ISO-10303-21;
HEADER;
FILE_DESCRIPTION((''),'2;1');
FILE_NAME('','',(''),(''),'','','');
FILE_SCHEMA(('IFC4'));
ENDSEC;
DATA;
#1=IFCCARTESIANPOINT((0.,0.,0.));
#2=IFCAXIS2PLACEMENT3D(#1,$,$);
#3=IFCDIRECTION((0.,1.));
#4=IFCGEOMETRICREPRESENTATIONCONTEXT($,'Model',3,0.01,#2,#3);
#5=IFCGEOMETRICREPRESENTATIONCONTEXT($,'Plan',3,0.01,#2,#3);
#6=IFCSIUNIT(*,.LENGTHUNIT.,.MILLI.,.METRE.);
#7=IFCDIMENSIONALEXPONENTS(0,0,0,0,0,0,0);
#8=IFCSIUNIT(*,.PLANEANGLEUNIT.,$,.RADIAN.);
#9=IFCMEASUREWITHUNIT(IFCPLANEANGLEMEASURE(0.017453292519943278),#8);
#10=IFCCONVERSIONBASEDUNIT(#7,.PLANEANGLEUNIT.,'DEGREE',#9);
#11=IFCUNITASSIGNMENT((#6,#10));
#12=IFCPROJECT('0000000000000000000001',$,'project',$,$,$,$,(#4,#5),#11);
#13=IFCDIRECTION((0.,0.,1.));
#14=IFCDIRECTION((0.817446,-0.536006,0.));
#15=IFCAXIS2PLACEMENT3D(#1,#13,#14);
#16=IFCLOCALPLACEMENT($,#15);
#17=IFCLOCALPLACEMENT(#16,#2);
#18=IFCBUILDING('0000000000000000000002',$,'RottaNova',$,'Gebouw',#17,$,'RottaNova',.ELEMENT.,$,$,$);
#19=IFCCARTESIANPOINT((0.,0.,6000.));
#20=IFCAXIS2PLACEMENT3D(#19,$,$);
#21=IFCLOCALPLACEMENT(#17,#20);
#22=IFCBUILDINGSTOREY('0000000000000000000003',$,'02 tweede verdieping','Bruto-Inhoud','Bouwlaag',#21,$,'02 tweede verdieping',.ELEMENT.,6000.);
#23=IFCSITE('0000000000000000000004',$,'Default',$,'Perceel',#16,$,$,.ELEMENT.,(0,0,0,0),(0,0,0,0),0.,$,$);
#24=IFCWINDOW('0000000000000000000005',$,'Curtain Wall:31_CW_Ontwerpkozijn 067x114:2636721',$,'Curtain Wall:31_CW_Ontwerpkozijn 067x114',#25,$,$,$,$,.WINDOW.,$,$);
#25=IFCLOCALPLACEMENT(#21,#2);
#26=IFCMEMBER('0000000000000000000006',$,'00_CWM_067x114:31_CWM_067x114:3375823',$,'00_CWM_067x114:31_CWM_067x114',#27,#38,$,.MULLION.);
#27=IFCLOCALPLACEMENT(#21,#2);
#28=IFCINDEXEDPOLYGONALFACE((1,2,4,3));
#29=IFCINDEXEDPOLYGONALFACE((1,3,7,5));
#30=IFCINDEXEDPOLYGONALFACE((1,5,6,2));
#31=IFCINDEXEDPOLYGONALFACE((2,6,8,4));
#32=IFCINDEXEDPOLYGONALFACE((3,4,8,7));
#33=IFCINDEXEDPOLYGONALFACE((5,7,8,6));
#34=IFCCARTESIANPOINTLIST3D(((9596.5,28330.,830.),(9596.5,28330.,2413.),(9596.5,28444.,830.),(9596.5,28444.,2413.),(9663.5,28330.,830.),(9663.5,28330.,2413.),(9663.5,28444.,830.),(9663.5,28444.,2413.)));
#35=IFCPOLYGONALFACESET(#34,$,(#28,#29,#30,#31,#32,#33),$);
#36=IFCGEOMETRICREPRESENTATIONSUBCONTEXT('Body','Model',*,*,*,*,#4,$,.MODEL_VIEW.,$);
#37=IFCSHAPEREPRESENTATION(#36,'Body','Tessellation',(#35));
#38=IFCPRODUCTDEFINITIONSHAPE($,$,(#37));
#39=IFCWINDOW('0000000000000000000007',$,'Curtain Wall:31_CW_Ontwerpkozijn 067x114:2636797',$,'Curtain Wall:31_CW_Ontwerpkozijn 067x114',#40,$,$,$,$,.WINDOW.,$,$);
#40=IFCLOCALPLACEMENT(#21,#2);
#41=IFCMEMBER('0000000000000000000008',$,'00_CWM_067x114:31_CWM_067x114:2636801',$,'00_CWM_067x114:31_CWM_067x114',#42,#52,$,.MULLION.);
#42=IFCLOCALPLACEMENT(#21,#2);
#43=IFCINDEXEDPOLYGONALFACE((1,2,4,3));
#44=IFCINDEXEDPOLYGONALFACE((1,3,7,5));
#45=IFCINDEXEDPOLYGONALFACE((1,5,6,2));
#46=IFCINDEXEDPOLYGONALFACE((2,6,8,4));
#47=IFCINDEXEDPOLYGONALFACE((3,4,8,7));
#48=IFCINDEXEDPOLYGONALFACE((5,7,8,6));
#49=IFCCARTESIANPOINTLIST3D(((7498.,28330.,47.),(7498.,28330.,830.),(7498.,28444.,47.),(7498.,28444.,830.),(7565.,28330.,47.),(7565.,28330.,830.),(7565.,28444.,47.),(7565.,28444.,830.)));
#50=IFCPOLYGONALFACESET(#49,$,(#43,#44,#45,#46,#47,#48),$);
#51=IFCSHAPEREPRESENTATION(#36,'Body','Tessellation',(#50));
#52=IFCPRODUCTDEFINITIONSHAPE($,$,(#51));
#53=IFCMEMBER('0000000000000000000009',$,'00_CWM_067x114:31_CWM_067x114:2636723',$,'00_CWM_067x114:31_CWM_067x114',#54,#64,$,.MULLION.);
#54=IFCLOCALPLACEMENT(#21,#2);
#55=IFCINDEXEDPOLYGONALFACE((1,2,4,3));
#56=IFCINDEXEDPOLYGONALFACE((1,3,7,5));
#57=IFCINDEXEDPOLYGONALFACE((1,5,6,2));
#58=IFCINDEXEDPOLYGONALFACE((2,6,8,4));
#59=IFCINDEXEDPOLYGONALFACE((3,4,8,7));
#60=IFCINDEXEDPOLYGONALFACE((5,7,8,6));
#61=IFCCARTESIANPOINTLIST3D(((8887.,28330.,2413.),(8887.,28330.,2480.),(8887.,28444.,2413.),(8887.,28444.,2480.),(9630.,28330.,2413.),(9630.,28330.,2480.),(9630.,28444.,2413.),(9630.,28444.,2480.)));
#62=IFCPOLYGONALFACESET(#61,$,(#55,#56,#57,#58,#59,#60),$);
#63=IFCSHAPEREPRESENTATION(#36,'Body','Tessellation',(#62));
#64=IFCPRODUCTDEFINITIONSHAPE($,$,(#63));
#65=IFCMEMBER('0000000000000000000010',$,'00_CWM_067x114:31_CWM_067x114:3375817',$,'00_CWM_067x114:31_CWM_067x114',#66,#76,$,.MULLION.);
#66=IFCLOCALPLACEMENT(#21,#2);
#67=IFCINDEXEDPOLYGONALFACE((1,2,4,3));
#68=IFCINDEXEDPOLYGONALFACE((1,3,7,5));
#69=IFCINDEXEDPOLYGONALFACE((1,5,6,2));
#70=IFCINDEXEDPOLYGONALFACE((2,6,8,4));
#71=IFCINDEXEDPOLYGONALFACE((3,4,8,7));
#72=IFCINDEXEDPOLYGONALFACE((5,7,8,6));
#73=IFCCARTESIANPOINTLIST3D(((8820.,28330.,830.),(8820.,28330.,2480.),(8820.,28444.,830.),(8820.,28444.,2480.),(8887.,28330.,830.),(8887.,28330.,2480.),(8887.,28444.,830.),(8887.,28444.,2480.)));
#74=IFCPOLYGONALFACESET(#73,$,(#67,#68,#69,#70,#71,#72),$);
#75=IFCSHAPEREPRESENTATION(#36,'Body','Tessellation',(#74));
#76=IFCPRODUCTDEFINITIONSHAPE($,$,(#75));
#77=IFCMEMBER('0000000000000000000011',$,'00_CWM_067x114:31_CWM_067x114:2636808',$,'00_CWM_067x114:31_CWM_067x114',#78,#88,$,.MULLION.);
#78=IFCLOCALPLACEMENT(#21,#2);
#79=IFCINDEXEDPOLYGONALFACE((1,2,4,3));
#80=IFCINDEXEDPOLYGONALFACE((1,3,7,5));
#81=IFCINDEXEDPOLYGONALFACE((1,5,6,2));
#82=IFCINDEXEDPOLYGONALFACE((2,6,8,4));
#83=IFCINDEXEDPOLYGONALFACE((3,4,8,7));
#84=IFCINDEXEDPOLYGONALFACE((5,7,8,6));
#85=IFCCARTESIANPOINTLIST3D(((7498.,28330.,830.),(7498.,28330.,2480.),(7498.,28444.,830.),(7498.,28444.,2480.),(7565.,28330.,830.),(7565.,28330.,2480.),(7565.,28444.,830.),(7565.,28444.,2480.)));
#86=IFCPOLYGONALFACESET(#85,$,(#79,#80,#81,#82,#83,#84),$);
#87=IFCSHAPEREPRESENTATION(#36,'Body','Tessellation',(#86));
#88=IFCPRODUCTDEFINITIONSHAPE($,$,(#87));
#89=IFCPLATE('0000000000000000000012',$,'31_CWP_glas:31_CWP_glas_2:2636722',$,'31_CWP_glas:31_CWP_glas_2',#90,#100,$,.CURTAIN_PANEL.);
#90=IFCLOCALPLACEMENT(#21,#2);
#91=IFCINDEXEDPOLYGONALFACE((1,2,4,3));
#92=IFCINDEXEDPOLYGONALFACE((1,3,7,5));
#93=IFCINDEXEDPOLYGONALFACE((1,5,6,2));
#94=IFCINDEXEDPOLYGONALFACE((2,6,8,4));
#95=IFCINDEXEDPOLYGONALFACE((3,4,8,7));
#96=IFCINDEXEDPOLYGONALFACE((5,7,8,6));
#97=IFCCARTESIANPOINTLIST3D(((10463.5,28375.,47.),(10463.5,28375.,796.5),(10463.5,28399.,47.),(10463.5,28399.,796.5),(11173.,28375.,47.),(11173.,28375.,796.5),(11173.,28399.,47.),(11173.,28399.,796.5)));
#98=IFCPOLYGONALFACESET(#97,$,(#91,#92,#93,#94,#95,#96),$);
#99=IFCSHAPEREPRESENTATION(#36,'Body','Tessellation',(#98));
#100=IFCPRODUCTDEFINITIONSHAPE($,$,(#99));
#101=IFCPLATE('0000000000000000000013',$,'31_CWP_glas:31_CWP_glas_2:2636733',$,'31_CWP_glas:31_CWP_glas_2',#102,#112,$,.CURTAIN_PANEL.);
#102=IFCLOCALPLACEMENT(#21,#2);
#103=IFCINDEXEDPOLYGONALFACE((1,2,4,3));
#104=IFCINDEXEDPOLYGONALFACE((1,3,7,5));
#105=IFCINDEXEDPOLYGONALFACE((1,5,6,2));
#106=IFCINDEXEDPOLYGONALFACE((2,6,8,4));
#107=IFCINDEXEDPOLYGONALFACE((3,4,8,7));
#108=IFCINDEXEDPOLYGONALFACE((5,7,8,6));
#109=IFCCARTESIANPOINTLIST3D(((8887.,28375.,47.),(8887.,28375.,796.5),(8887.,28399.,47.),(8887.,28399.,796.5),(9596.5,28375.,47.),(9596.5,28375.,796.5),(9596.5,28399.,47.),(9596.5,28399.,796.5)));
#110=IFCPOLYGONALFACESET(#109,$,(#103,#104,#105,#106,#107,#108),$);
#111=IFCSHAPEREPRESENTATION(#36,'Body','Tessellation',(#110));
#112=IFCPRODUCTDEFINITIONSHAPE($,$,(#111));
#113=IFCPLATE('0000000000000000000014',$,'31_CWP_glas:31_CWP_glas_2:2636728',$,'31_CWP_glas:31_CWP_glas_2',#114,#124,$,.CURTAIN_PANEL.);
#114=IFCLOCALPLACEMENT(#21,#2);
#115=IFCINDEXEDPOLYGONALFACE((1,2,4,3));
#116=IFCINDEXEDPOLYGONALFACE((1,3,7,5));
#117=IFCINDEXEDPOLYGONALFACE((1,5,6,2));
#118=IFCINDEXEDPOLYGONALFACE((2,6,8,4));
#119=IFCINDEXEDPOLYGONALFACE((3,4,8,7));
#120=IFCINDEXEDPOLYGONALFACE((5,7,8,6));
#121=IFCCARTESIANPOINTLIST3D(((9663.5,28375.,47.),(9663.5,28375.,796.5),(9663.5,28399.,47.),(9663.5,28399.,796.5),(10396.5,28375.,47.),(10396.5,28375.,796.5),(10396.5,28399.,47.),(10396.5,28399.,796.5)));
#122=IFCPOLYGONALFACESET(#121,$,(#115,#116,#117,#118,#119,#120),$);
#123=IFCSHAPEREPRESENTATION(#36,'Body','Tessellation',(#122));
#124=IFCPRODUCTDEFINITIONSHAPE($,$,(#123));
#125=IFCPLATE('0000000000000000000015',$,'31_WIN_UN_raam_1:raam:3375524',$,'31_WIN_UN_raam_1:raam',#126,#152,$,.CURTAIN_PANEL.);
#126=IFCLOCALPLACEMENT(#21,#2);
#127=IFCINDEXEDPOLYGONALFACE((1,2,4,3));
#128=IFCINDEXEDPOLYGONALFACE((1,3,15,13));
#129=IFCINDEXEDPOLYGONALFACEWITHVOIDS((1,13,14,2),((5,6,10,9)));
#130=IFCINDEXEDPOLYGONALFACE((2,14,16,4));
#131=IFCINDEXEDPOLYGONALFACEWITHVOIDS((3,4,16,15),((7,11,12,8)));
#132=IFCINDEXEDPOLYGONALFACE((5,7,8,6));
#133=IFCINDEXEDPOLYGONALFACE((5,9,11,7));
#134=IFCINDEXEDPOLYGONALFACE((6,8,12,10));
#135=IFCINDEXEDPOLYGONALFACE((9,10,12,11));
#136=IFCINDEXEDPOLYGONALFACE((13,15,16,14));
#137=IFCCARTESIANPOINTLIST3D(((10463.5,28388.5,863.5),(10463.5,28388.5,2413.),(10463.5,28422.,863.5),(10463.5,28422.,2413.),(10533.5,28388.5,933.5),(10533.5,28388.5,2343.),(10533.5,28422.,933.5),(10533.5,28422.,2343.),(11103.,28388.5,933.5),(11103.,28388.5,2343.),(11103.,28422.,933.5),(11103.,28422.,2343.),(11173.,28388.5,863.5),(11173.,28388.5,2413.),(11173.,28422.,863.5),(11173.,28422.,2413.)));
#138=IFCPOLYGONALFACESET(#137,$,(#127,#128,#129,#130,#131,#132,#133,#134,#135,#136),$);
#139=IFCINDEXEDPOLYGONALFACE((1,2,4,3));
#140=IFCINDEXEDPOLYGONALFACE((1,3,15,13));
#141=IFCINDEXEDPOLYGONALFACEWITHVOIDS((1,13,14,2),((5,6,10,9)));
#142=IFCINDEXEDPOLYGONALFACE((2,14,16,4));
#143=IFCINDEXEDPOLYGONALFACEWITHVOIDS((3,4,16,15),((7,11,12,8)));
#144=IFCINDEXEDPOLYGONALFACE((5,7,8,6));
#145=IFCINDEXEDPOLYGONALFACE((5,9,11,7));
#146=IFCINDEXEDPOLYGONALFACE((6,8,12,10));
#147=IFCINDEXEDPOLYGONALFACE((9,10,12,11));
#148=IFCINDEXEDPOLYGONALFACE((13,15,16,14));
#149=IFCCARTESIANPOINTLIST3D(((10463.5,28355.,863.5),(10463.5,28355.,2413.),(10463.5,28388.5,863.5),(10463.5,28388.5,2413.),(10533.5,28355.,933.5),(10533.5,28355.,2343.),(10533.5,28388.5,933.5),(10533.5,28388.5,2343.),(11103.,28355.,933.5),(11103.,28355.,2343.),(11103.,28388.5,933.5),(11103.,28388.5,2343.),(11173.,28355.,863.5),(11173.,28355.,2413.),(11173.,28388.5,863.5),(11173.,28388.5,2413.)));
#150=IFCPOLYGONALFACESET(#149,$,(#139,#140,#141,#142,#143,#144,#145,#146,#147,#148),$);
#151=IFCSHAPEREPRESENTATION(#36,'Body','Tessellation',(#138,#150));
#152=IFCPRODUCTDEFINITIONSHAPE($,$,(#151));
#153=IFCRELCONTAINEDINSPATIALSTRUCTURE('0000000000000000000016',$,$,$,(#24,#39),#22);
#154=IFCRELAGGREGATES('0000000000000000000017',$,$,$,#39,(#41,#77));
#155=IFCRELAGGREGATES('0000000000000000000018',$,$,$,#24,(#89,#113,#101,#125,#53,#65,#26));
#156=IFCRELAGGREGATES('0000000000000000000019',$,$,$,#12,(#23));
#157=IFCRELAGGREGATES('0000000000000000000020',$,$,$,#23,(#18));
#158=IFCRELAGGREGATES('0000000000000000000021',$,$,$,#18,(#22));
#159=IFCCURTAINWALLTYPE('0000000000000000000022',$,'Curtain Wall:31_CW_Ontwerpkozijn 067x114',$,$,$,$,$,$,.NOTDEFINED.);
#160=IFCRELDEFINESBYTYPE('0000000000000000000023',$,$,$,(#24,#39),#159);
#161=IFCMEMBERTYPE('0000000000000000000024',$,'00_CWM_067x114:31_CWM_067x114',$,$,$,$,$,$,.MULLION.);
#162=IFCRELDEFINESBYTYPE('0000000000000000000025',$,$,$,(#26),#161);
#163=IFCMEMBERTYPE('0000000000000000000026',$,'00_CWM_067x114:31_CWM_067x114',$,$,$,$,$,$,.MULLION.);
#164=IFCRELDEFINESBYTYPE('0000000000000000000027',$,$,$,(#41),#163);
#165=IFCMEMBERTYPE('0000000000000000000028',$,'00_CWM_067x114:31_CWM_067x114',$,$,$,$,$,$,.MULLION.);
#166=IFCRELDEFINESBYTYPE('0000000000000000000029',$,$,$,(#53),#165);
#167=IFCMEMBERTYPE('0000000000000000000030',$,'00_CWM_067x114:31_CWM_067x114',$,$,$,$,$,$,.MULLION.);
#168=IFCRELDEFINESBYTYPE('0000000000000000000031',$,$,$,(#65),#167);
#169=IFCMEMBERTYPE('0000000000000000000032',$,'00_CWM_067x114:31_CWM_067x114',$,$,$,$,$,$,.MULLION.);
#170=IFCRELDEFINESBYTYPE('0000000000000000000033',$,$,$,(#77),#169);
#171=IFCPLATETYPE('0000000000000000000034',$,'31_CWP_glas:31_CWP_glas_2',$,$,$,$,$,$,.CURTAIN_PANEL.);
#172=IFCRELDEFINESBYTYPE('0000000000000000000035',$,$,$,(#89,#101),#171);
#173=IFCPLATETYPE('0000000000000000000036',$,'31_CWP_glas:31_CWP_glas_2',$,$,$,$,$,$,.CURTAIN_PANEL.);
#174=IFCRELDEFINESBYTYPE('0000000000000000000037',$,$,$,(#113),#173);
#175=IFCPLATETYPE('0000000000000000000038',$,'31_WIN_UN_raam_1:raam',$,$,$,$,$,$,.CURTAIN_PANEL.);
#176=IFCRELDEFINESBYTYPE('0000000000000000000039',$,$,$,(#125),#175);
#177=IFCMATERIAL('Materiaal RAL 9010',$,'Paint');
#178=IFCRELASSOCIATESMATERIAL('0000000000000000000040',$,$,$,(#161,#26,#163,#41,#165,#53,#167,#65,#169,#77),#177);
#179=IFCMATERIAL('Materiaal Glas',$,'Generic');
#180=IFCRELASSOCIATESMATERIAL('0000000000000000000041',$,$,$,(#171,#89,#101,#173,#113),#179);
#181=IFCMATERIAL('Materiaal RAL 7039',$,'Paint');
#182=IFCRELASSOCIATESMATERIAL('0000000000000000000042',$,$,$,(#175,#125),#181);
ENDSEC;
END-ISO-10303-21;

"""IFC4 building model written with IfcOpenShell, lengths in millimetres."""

from ifc_helpers import new_model, entity, si_unit, converted_unit, direction, frame, origin, place, context, subcontext, project, spatial, indexed_curve, outline, extrude, source, transform, mapped, material, type_object, type_shapes, element, aggregate, save


model = new_model("IFC4")

# Units and contexts
model_context = context("Model", 3, precision=0.01, world=origin(), true_north=direction((0.0, 1.0)))
plan_context = context("Plan", 3, precision=0.01, world=origin(), true_north=direction((0.0, 1.0)))
body_context = subcontext(model_context, "Body", "Model", "MODEL_VIEW")
ifc_project = project(units=[si_unit("LENGTHUNIT", "METRE", prefix="MILLI"), converted_unit("PLANEANGLEUNIT", "DEGREE", entity("IfcPlaneAngleMeasure", 0.017453292519943278), si_unit("PLANEANGLEUNIT", "RADIAN"), dimensions=[0, 0, 0, 0, 0, 0, 0])], contexts=[model_context, plan_context])

# Site, building, storey
site_placement = place(None, frame((0.0, 0.0, 0.0), z_axis=(0.0, 0.0, 1.0), x_axis=(0.817446, -0.536006, 0.0)))
site = spatial("IfcSite", under=ifc_project, at=site_placement, Name="Default", ObjectType="Perceel", CompositionType="ELEMENT", RefLatitude=(0, 0, 0, 0), RefLongitude=(0, 0, 0, 0), RefElevation=0.0)
building_placement = place(site_placement, origin())
building = spatial("IfcBuilding", under=site, at=building_placement, Name="RottaNova", ObjectType="Gebouw", LongName="RottaNova", CompositionType="ELEMENT")
storey_placement = place(building_placement, frame((0.0, 0.0, 6000.0)))
storey = spatial("IfcBuildingStorey", under=building, at=storey_placement, Name="02 tweede verdieping", Description="Bruto-Inhoud", ObjectType="Bouwlaag", LongName="02 tweede verdieping", CompositionType="ELEMENT", Elevation=6000.0)

# Window, member
curtain_wall_type = type_object("IfcCurtainWallType", Name="Curtain Wall:31_CW_Ontwerpkozijn 067x114", PredefinedType="NOTDEFINED")
window_1_placement = place(storey_placement, frame((0.0, 0.0, -6000.0)))
window_1 = element("IfcWindow", 1, at=window_1_placement, inside=storey, type_object=curtain_wall_type, Name="Curtain Wall:31_CW_Ontwerpkozijn 067x114:2636721", ObjectType="Curtain Wall:31_CW_Ontwerpkozijn 067x114", PredefinedType="WINDOW")
ifc_material_1 = material(Name="Materiaal RAL 9010", Category="Paint")
member_type_1 = type_object("IfcMemberType", Name="00_CWM_067x114:31_CWM_067x114", PredefinedType="MULLION", material=ifc_material_1)
shared_shape_1 = source(origin(), body_context, "Body", "SweptSolid", [
    extrude(outline(indexed_curve([(-33.5, -57.0), (33.5, -57.0), (33.5, 57.0), (-33.5, 57.0), (-33.5, -57.0)], self_intersect=False)), frame((0.0, 57.0, -1583.0), z_axis=(0.0, 0.0, 1.0), x_axis=(-1.0, 0.0, 0.0)), (0.0, 0.0, 1.0), 1583.0),
])
type_shapes(member_type_1, [shared_shape_1])
member_1_placement = place(window_1_placement, frame((9630.0, 28330.0, 6830.0), z_axis=(0.0, 0.0, -1.0), x_axis=(-1.0, 0.0, 0.0)))
member_1 = element("IfcMember", 2, at=member_1_placement, type_object=member_type_1, material=ifc_material_1, Name="00_CWM_067x114:31_CWM_067x114:3375823", ObjectType="00_CWM_067x114:31_CWM_067x114", PredefinedType="MULLION", context=body_context, shape_type="MappedRepresentation", body=[
    mapped(shared_shape_1, transform((0.0, 0.0, 0.0), scale=1.0)),
])

# Window, member
window_2_placement = place(storey_placement, frame((0.0, 0.0, -6000.0)))
window_2 = element("IfcWindow", 3, at=window_2_placement, inside=storey, type_object=curtain_wall_type, Name="Curtain Wall:31_CW_Ontwerpkozijn 067x114:2636797", ObjectType="Curtain Wall:31_CW_Ontwerpkozijn 067x114", PredefinedType="WINDOW")
member_type_2 = type_object("IfcMemberType", Name="00_CWM_067x114:31_CWM_067x114", PredefinedType="MULLION", material=ifc_material_1)
shared_shape_2 = source(origin(), body_context, "Body", "SweptSolid", [
    extrude(outline(indexed_curve([(-33.5, -57.0), (33.5, -57.0), (33.5, 57.0), (-33.5, 57.0), (-33.5, -57.0)], self_intersect=False)), frame((-33.5, -57.0, -783.0), z_axis=(0.0, 0.0, 1.0), x_axis=(-1.0, 0.0, 0.0)), (0.0, 0.0, 1.0), 783.0),
])
type_shapes(member_type_2, [shared_shape_2])
member_2_placement = place(window_2_placement, frame((7565.0, 28330.0, 6047.0), z_axis=(0.0, 0.0, -1.0), x_axis=(1.0, 0.0, 0.0)))
member_2 = element("IfcMember", 4, at=member_2_placement, type_object=member_type_2, material=ifc_material_1, Name="00_CWM_067x114:31_CWM_067x114:2636801", ObjectType="00_CWM_067x114:31_CWM_067x114", PredefinedType="MULLION", context=body_context, shape_type="MappedRepresentation", body=[
    mapped(shared_shape_2, transform((0.0, 0.0, 0.0), scale=1.0)),
])

# Members
member_type_3 = type_object("IfcMemberType", Name="00_CWM_067x114:31_CWM_067x114", PredefinedType="MULLION", material=ifc_material_1)
shared_shape_3 = source(origin(), body_context, "Body", "SweptSolid", [
    extrude(outline(indexed_curve([(-33.5, -57.0), (33.5, -57.0), (33.5, 57.0), (-33.5, 57.0), (-33.5, -57.0)], self_intersect=False)), frame((-33.5, 57.0, -743.0), z_axis=(0.0, 0.0, 1.0), x_axis=(-1.0, 0.0, 0.0)), (0.0, 0.0, 1.0), 743.0),
])
type_shapes(member_type_3, [shared_shape_3])
member_3_placement = place(window_1_placement, frame((8887.0, 28330.0, 8480.0), z_axis=(-1.0, 0.0, 0.0), x_axis=(0.0, 0.0, 1.0)))
member_3 = element("IfcMember", 5, at=member_3_placement, type_object=member_type_3, material=ifc_material_1, Name="00_CWM_067x114:31_CWM_067x114:2636723", ObjectType="00_CWM_067x114:31_CWM_067x114", PredefinedType="MULLION", context=body_context, shape_type="MappedRepresentation", body=[
    mapped(shared_shape_3, transform((0.0, 0.0, 0.0), scale=1.0)),
])
member_type_4 = type_object("IfcMemberType", Name="00_CWM_067x114:31_CWM_067x114", PredefinedType="MULLION", material=ifc_material_1)
shared_shape_4 = source(origin(), body_context, "Body", "SweptSolid", [
    extrude(outline(indexed_curve([(-33.5, -57.0), (33.5, -57.0), (33.5, 57.0), (-33.5, 57.0), (-33.5, -57.0)], self_intersect=False)), frame((-33.5, 57.0, -1650.0), z_axis=(0.0, 0.0, 1.0), x_axis=(-1.0, 0.0, 0.0)), (0.0, 0.0, 1.0), 1650.0),
])
type_shapes(member_type_4, [shared_shape_4])
member_4_placement = place(window_1_placement, frame((8820.0, 28330.0, 6830.0), z_axis=(0.0, 0.0, -1.0), x_axis=(-1.0, 0.0, 0.0)))
member_4 = element("IfcMember", 6, at=member_4_placement, type_object=member_type_4, material=ifc_material_1, Name="00_CWM_067x114:31_CWM_067x114:3375817", ObjectType="00_CWM_067x114:31_CWM_067x114", PredefinedType="MULLION", context=body_context, shape_type="MappedRepresentation", body=[
    mapped(shared_shape_4, transform((0.0, 0.0, 0.0), scale=1.0)),
])
member_type_5 = type_object("IfcMemberType", Name="00_CWM_067x114:31_CWM_067x114", PredefinedType="MULLION", material=ifc_material_1)
shared_shape_5 = source(origin(), body_context, "Body", "SweptSolid", [
    extrude(outline(indexed_curve([(-33.5, -57.0), (33.5, -57.0), (33.5, 57.0), (-33.5, 57.0), (-33.5, -57.0)], self_intersect=False)), frame((-33.5, -57.0, -1650.0), z_axis=(0.0, 0.0, 1.0), x_axis=(-1.0, 0.0, 0.0)), (0.0, 0.0, 1.0), 1650.0),
])
type_shapes(member_type_5, [shared_shape_5])
member_5_placement = place(window_2_placement, frame((7565.0, 28330.0, 6830.0), z_axis=(0.0, 0.0, -1.0), x_axis=(1.0, 0.0, 0.0)))
member_5 = element("IfcMember", 7, at=member_5_placement, type_object=member_type_5, material=ifc_material_1, Name="00_CWM_067x114:31_CWM_067x114:2636808", ObjectType="00_CWM_067x114:31_CWM_067x114", PredefinedType="MULLION", context=body_context, shape_type="MappedRepresentation", body=[
    mapped(shared_shape_5, transform((0.0, 0.0, 0.0), scale=1.0)),
])
aggregate(window_2, [member_2, member_5])

# Plates
ifc_material_2 = material(Name="Materiaal Glas", Category="Generic")
plate_type_1 = type_object("IfcPlateType", Name="31_CWP_glas:31_CWP_glas_2", PredefinedType="CURTAIN_PANEL", material=ifc_material_2)
shared_shape_6 = source(origin(), body_context, "Body", "SweptSolid", [
    extrude(outline(indexed_curve([(-12.0, -354.8), (12.0, -354.8), (12.0, 354.8), (-12.0, 354.8), (-12.0, -354.8)], self_intersect=False)), frame((0.0, -57.0, 0.0), z_axis=(0.0, 0.0, 1.0), x_axis=(0.0, 1.0, 0.0)), (0.0, 0.0, 1.0), 749.5),
])
type_shapes(plate_type_1, [shared_shape_6])
plate_1_placement = place(window_1_placement, frame((10818.2, 28330.0, 6047.0), z_axis=(0.0, 0.0, 1.0), x_axis=(-1.0, 0.0, 0.0)))
plate_1 = element("IfcPlate", 8, at=plate_1_placement, type_object=plate_type_1, material=ifc_material_2, Name="31_CWP_glas:31_CWP_glas_2:2636722", ObjectType="31_CWP_glas:31_CWP_glas_2", PredefinedType="CURTAIN_PANEL", context=body_context, shape_type="MappedRepresentation", body=[
    mapped(shared_shape_6, transform((0.0, 0.0, 0.0), scale=1.0)),
])
plate_2_placement = place(window_1_placement, frame((9241.7, 28330.0, 6047.0), z_axis=(0.0, 0.0, 1.0), x_axis=(-1.0, 0.0, 0.0)))
plate_2 = element("IfcPlate", 9, at=plate_2_placement, type_object=plate_type_1, material=ifc_material_2, Name="31_CWP_glas:31_CWP_glas_2:2636733", ObjectType="31_CWP_glas:31_CWP_glas_2", PredefinedType="CURTAIN_PANEL", context=body_context, shape_type="MappedRepresentation", body=[
    mapped(shared_shape_6, transform((0.0, 0.0, 0.0), scale=1.0)),
])
plate_type_2 = type_object("IfcPlateType", Name="31_CWP_glas:31_CWP_glas_2", PredefinedType="CURTAIN_PANEL", material=ifc_material_2)
shared_shape_7 = source(origin(), body_context, "Body", "SweptSolid", [
    extrude(outline(indexed_curve([(-12.0, -366.5), (12.0, -366.5), (12.0, 366.5), (-12.0, 366.5), (-12.0, -366.5)], self_intersect=False)), frame((0.0, -57.0, 0.0), z_axis=(0.0, 0.0, 1.0), x_axis=(0.0, 1.0, 0.0)), (0.0, 0.0, 1.0), 749.5),
])
type_shapes(plate_type_2, [shared_shape_7])
plate_3_placement = place(window_1_placement, frame((10030.0, 28330.0, 6047.0), z_axis=(0.0, 0.0, 1.0), x_axis=(-1.0, 0.0, 0.0)))
plate_3 = element("IfcPlate", 10, at=plate_3_placement, type_object=plate_type_2, material=ifc_material_2, Name="31_CWP_glas:31_CWP_glas_2:2636728", ObjectType="31_CWP_glas:31_CWP_glas_2", PredefinedType="CURTAIN_PANEL", context=body_context, shape_type="MappedRepresentation", body=[
    mapped(shared_shape_7, transform((0.0, 0.0, 0.0), scale=1.0)),
])
ifc_material_3 = material(Name="Materiaal RAL 7039", Category="Paint")
plate_type_3 = type_object("IfcPlateType", Name="31_WIN_UN_raam_1:raam", PredefinedType="CURTAIN_PANEL", material=ifc_material_3)
shared_shape_8 = source(origin(), body_context, "Body", "SweptSolid", [
    extrude(outline(indexed_curve([(-354.7, -774.7), (354.7, -774.7), (354.7, 774.7), (-354.7, 774.7), (-354.7, -774.7)], self_intersect=False), holes=[indexed_curve([(-284.7, 704.7), (284.7, 704.7), (284.7, -704.8), (-284.7, -704.8), (-284.7, 704.7)], self_intersect=False)]), frame((0.0, -92.0, 774.8), z_axis=(0.0, 1.0, 0.0), x_axis=(1.0, 0.0, 0.0)), (0.0, 0.0, 1.0), 33.5),
    extrude(outline(indexed_curve([(-354.7, -774.7), (354.7, -774.7), (354.7, 774.7), (-354.7, 774.7), (-354.7, -774.7)], self_intersect=False), holes=[indexed_curve([(-284.7, 704.7), (284.7, 704.7), (284.7, -704.8), (-284.7, -704.8), (-284.7, 704.7)], self_intersect=False)]), frame((0.0, -58.5, 774.8), z_axis=(0.0, 1.0, 0.0), x_axis=(1.0, 0.0, 0.0)), (0.0, 0.0, 1.0), 33.5),
])
type_shapes(plate_type_3, [shared_shape_8])
plate_4_placement = place(window_1_placement, frame((10818.2, 28330.0, 6863.5), z_axis=(0.0, 0.0, 1.0), x_axis=(-1.0, 0.0, 0.0)))
plate_4 = element("IfcPlate", 11, at=plate_4_placement, type_object=plate_type_3, material=ifc_material_3, Name="31_WIN_UN_raam_1:raam:3375524", ObjectType="31_WIN_UN_raam_1:raam", PredefinedType="CURTAIN_PANEL", context=body_context, shape_type="MappedRepresentation", body=[
    mapped(shared_shape_8, transform((0.0, 0.0, 0.0), scale=1.0)),
])
aggregate(window_1, [plate_1, plate_3, plate_2, plate_4, member_3, member_4, member_1])

save(model, "model.ifc")
